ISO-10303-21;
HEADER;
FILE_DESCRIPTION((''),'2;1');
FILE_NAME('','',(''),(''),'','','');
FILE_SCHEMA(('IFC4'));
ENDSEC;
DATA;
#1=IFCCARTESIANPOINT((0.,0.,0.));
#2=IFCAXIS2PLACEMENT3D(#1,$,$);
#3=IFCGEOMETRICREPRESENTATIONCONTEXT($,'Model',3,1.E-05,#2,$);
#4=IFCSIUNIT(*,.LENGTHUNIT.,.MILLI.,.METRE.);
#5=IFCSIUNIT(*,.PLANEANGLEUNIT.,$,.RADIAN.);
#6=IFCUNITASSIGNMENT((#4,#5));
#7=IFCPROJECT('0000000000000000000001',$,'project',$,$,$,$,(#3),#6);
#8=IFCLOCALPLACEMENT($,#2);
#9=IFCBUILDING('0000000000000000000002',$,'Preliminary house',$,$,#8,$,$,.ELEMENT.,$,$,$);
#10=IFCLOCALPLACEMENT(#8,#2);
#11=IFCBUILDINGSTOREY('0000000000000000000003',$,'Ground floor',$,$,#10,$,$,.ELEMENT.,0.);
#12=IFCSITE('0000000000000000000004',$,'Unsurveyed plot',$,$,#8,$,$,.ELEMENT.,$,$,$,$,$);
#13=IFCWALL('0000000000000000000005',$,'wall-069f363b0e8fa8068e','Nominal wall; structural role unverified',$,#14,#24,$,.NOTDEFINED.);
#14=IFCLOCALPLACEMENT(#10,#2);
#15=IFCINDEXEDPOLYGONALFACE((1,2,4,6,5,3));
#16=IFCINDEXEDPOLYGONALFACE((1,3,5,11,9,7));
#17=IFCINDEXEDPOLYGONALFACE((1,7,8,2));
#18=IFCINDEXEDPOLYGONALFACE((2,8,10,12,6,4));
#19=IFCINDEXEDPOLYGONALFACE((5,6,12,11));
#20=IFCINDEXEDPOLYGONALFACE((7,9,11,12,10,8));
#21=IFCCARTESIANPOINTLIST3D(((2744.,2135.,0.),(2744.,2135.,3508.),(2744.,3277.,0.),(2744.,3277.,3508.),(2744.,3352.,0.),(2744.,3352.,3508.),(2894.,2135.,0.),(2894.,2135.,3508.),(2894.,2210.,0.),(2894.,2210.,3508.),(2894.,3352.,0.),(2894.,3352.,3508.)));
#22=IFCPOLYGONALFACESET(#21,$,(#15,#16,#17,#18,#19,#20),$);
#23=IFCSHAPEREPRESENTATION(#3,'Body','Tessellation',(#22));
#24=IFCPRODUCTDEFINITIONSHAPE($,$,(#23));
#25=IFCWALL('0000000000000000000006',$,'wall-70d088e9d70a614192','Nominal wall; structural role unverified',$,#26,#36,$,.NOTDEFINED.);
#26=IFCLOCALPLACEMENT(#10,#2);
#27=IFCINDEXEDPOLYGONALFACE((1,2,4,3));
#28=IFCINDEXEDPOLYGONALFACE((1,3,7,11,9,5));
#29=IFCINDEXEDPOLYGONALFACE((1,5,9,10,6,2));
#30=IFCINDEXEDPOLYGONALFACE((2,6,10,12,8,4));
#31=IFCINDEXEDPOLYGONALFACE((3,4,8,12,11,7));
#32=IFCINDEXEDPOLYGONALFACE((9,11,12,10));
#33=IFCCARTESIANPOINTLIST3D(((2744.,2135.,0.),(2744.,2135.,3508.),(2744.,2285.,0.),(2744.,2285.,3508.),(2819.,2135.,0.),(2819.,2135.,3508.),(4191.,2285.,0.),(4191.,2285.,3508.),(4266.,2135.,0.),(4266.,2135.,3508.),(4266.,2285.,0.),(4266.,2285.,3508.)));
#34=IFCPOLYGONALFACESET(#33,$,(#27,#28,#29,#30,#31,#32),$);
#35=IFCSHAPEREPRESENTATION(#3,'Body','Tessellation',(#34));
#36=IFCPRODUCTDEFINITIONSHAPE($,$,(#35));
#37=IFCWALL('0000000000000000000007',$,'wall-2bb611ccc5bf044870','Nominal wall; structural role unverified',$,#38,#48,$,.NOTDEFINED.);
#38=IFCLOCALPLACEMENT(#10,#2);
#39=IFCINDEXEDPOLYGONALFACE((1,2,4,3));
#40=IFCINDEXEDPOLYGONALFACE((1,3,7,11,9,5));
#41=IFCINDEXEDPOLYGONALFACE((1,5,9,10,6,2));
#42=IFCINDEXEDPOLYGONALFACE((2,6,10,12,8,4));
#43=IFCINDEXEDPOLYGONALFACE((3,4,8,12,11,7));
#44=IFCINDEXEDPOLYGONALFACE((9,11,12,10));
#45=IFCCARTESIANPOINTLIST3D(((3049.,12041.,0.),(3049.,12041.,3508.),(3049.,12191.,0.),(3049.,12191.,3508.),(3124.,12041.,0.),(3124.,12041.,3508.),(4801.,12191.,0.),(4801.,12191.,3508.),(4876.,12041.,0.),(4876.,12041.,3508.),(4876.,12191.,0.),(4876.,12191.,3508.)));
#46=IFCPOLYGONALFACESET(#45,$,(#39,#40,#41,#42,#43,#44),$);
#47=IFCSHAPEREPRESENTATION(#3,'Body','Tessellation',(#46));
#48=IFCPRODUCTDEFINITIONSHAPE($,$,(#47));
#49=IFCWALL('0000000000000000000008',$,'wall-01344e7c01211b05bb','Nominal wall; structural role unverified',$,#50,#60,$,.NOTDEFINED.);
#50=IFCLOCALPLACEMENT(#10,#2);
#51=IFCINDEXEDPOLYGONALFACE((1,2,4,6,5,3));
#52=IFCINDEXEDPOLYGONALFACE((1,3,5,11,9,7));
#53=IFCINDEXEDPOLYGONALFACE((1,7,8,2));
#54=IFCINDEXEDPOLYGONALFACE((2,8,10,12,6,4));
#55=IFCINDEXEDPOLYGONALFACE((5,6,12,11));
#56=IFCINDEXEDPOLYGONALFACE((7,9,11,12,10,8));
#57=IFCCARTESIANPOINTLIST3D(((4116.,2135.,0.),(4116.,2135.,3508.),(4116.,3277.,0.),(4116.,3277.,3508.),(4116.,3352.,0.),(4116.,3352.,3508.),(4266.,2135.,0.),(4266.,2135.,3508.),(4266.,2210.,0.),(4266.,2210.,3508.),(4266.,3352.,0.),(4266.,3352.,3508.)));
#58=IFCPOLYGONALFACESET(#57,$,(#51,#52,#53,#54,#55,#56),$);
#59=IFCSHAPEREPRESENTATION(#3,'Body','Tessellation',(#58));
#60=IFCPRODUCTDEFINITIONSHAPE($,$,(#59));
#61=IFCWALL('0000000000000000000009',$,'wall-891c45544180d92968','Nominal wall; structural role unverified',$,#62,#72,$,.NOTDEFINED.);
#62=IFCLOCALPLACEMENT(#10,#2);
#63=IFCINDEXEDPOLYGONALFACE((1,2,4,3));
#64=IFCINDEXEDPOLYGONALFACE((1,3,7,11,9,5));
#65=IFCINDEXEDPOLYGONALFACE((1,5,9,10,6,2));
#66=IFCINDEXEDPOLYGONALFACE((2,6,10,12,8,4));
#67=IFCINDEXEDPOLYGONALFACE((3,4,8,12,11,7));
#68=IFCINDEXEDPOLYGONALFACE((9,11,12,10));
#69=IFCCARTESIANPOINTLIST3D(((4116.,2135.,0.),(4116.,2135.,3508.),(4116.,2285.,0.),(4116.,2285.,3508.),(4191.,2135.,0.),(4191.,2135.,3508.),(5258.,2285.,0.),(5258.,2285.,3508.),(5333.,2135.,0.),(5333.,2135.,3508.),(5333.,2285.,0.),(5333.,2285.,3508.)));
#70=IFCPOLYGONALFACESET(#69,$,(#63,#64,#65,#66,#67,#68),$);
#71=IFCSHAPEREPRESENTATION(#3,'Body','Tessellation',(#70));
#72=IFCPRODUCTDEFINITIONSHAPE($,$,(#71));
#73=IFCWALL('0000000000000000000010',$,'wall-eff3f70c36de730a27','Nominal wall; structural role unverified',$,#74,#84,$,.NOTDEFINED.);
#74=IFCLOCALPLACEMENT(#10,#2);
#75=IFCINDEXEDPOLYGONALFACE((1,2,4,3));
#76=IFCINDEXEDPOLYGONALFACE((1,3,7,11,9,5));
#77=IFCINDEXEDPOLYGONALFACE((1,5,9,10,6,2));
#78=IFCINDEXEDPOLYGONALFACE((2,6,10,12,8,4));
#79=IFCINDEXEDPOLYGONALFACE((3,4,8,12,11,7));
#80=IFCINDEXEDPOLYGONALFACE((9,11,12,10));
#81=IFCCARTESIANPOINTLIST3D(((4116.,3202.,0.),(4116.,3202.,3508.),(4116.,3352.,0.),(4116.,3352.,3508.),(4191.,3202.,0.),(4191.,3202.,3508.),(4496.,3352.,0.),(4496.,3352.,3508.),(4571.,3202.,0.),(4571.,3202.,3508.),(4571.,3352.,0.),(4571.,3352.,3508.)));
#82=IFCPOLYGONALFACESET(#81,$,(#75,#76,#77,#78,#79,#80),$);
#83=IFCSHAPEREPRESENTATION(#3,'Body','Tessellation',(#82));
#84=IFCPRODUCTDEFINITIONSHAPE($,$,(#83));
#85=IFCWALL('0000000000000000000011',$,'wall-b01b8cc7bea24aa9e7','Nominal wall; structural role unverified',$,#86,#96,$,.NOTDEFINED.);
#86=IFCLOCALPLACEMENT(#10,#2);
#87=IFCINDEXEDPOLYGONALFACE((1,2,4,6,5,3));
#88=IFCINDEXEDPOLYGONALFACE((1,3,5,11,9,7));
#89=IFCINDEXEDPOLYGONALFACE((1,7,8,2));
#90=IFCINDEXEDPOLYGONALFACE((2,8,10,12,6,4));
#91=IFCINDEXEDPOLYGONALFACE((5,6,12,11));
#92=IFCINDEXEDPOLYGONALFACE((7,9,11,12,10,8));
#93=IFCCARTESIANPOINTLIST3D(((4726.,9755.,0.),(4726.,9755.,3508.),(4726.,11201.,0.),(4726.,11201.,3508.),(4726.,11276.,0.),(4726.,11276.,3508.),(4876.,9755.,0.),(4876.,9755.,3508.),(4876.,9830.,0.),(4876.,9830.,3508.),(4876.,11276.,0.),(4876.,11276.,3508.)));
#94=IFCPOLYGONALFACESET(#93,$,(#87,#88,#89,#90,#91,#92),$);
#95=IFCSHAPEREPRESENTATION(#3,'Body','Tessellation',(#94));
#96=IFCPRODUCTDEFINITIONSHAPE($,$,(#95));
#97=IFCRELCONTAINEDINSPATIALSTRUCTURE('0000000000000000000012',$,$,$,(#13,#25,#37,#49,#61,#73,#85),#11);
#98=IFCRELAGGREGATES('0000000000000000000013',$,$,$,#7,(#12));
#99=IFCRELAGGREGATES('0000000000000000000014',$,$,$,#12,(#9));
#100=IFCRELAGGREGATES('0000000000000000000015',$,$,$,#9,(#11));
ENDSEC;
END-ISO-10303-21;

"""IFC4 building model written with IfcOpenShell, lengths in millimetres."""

from ifc_helpers import new_model, si_unit, origin, place, context, project, spatial, polyline, outline, extrude, element, save


model = new_model("IFC4")

# Units and contexts
model_context = context("Model", 3, precision=1e-05, world=origin())
ifc_project = project(units=[si_unit("LENGTHUNIT", "METRE", prefix="MILLI"), si_unit("PLANEANGLEUNIT", "RADIAN")], contexts=[model_context])

# Site, building, storey
placement_1 = place(None, origin())
site = spatial("IfcSite", under=ifc_project, at=placement_1, Name="Unsurveyed plot", CompositionType="ELEMENT")
building = spatial("IfcBuilding", under=site, at=placement_1, Name="Preliminary house", CompositionType="ELEMENT")
placement_2 = place(placement_1, origin())
storey = spatial("IfcBuildingStorey", under=building, at=placement_2, Name="Ground floor", CompositionType="ELEMENT", Elevation=0.0)

# Walls
element("IfcWall", 1, at=placement_2, inside=storey, Name="wall-069f363b0e8fa8068e", Description="Nominal wall; structural role unverified", PredefinedType="NOTDEFINED", context=model_context, shape_type="SweptSolid", body=[
    extrude(outline(polyline([(2744.0, 3277.0), (2744.0, 3352.0), (2894.0, 3352.0), (2894.0, 2210.0), (2894.0, 2135.0), (2744.0, 2135.0), (2744.0, 3277.0)])), origin(), (0.0, 0.0, 1.0), 3508.0),
])
element("IfcWall", 2, at=placement_2, inside=storey, Name="wall-70d088e9d70a614192", Description="Nominal wall; structural role unverified", PredefinedType="NOTDEFINED", context=model_context, shape_type="SweptSolid", body=[
    extrude(outline(polyline([(4191.0, 2285.0), (4266.0, 2285.0), (4266.0, 2135.0), (2819.0, 2135.0), (2744.0, 2135.0), (2744.0, 2285.0), (4191.0, 2285.0)])), origin(), (0.0, 0.0, 1.0), 3508.0),
])

# Wall
element("IfcWall", 3, at=placement_2, inside=storey, Name="wall-2bb611ccc5bf044870", Description="Nominal wall; structural role unverified", PredefinedType="NOTDEFINED", context=model_context, shape_type="SweptSolid", body=[
    extrude(outline(polyline([(4801.0, 12191.0), (4876.0, 12191.0), (4876.0, 12041.0), (3124.0, 12041.0), (3049.0, 12041.0), (3049.0, 12191.0), (4801.0, 12191.0)])), origin(), (0.0, 0.0, 1.0), 3508.0),
])

# Walls
element("IfcWall", 4, at=placement_2, inside=storey, Name="wall-01344e7c01211b05bb", Description="Nominal wall; structural role unverified", PredefinedType="NOTDEFINED", context=model_context, shape_type="SweptSolid", body=[
    extrude(outline(polyline([(4116.0, 3277.0), (4116.0, 3352.0), (4266.0, 3352.0), (4266.0, 2210.0), (4266.0, 2135.0), (4116.0, 2135.0), (4116.0, 3277.0)])), origin(), (0.0, 0.0, 1.0), 3508.0),
])
element("IfcWall", 5, at=placement_2, inside=storey, Name="wall-891c45544180d92968", Description="Nominal wall; structural role unverified", PredefinedType="NOTDEFINED", context=model_context, shape_type="SweptSolid", body=[
    extrude(outline(polyline([(5258.0, 2285.0), (5333.0, 2285.0), (5333.0, 2135.0), (4191.0, 2135.0), (4116.0, 2135.0), (4116.0, 2285.0), (5258.0, 2285.0)])), origin(), (0.0, 0.0, 1.0), 3508.0),
])
element("IfcWall", 6, at=placement_2, inside=storey, Name="wall-eff3f70c36de730a27", Description="Nominal wall; structural role unverified", PredefinedType="NOTDEFINED", context=model_context, shape_type="SweptSolid", body=[
    extrude(outline(polyline([(4496.0, 3352.0), (4571.0, 3352.0), (4571.0, 3202.0), (4191.0, 3202.0), (4116.0, 3202.0), (4116.0, 3352.0), (4496.0, 3352.0)])), origin(), (0.0, 0.0, 1.0), 3508.0),
])

# Wall
element("IfcWall", 7, at=placement_2, inside=storey, Name="wall-b01b8cc7bea24aa9e7", Description="Nominal wall; structural role unverified", PredefinedType="NOTDEFINED", context=model_context, shape_type="SweptSolid", body=[
    extrude(outline(polyline([(4726.0, 11201.0), (4726.0, 11276.0), (4876.0, 11276.0), (4876.0, 9830.0), (4876.0, 9755.0), (4726.0, 9755.0), (4726.0, 11201.0)])), origin(), (0.0, 0.0, 1.0), 3508.0),
])

save(model, "model.ifc")
